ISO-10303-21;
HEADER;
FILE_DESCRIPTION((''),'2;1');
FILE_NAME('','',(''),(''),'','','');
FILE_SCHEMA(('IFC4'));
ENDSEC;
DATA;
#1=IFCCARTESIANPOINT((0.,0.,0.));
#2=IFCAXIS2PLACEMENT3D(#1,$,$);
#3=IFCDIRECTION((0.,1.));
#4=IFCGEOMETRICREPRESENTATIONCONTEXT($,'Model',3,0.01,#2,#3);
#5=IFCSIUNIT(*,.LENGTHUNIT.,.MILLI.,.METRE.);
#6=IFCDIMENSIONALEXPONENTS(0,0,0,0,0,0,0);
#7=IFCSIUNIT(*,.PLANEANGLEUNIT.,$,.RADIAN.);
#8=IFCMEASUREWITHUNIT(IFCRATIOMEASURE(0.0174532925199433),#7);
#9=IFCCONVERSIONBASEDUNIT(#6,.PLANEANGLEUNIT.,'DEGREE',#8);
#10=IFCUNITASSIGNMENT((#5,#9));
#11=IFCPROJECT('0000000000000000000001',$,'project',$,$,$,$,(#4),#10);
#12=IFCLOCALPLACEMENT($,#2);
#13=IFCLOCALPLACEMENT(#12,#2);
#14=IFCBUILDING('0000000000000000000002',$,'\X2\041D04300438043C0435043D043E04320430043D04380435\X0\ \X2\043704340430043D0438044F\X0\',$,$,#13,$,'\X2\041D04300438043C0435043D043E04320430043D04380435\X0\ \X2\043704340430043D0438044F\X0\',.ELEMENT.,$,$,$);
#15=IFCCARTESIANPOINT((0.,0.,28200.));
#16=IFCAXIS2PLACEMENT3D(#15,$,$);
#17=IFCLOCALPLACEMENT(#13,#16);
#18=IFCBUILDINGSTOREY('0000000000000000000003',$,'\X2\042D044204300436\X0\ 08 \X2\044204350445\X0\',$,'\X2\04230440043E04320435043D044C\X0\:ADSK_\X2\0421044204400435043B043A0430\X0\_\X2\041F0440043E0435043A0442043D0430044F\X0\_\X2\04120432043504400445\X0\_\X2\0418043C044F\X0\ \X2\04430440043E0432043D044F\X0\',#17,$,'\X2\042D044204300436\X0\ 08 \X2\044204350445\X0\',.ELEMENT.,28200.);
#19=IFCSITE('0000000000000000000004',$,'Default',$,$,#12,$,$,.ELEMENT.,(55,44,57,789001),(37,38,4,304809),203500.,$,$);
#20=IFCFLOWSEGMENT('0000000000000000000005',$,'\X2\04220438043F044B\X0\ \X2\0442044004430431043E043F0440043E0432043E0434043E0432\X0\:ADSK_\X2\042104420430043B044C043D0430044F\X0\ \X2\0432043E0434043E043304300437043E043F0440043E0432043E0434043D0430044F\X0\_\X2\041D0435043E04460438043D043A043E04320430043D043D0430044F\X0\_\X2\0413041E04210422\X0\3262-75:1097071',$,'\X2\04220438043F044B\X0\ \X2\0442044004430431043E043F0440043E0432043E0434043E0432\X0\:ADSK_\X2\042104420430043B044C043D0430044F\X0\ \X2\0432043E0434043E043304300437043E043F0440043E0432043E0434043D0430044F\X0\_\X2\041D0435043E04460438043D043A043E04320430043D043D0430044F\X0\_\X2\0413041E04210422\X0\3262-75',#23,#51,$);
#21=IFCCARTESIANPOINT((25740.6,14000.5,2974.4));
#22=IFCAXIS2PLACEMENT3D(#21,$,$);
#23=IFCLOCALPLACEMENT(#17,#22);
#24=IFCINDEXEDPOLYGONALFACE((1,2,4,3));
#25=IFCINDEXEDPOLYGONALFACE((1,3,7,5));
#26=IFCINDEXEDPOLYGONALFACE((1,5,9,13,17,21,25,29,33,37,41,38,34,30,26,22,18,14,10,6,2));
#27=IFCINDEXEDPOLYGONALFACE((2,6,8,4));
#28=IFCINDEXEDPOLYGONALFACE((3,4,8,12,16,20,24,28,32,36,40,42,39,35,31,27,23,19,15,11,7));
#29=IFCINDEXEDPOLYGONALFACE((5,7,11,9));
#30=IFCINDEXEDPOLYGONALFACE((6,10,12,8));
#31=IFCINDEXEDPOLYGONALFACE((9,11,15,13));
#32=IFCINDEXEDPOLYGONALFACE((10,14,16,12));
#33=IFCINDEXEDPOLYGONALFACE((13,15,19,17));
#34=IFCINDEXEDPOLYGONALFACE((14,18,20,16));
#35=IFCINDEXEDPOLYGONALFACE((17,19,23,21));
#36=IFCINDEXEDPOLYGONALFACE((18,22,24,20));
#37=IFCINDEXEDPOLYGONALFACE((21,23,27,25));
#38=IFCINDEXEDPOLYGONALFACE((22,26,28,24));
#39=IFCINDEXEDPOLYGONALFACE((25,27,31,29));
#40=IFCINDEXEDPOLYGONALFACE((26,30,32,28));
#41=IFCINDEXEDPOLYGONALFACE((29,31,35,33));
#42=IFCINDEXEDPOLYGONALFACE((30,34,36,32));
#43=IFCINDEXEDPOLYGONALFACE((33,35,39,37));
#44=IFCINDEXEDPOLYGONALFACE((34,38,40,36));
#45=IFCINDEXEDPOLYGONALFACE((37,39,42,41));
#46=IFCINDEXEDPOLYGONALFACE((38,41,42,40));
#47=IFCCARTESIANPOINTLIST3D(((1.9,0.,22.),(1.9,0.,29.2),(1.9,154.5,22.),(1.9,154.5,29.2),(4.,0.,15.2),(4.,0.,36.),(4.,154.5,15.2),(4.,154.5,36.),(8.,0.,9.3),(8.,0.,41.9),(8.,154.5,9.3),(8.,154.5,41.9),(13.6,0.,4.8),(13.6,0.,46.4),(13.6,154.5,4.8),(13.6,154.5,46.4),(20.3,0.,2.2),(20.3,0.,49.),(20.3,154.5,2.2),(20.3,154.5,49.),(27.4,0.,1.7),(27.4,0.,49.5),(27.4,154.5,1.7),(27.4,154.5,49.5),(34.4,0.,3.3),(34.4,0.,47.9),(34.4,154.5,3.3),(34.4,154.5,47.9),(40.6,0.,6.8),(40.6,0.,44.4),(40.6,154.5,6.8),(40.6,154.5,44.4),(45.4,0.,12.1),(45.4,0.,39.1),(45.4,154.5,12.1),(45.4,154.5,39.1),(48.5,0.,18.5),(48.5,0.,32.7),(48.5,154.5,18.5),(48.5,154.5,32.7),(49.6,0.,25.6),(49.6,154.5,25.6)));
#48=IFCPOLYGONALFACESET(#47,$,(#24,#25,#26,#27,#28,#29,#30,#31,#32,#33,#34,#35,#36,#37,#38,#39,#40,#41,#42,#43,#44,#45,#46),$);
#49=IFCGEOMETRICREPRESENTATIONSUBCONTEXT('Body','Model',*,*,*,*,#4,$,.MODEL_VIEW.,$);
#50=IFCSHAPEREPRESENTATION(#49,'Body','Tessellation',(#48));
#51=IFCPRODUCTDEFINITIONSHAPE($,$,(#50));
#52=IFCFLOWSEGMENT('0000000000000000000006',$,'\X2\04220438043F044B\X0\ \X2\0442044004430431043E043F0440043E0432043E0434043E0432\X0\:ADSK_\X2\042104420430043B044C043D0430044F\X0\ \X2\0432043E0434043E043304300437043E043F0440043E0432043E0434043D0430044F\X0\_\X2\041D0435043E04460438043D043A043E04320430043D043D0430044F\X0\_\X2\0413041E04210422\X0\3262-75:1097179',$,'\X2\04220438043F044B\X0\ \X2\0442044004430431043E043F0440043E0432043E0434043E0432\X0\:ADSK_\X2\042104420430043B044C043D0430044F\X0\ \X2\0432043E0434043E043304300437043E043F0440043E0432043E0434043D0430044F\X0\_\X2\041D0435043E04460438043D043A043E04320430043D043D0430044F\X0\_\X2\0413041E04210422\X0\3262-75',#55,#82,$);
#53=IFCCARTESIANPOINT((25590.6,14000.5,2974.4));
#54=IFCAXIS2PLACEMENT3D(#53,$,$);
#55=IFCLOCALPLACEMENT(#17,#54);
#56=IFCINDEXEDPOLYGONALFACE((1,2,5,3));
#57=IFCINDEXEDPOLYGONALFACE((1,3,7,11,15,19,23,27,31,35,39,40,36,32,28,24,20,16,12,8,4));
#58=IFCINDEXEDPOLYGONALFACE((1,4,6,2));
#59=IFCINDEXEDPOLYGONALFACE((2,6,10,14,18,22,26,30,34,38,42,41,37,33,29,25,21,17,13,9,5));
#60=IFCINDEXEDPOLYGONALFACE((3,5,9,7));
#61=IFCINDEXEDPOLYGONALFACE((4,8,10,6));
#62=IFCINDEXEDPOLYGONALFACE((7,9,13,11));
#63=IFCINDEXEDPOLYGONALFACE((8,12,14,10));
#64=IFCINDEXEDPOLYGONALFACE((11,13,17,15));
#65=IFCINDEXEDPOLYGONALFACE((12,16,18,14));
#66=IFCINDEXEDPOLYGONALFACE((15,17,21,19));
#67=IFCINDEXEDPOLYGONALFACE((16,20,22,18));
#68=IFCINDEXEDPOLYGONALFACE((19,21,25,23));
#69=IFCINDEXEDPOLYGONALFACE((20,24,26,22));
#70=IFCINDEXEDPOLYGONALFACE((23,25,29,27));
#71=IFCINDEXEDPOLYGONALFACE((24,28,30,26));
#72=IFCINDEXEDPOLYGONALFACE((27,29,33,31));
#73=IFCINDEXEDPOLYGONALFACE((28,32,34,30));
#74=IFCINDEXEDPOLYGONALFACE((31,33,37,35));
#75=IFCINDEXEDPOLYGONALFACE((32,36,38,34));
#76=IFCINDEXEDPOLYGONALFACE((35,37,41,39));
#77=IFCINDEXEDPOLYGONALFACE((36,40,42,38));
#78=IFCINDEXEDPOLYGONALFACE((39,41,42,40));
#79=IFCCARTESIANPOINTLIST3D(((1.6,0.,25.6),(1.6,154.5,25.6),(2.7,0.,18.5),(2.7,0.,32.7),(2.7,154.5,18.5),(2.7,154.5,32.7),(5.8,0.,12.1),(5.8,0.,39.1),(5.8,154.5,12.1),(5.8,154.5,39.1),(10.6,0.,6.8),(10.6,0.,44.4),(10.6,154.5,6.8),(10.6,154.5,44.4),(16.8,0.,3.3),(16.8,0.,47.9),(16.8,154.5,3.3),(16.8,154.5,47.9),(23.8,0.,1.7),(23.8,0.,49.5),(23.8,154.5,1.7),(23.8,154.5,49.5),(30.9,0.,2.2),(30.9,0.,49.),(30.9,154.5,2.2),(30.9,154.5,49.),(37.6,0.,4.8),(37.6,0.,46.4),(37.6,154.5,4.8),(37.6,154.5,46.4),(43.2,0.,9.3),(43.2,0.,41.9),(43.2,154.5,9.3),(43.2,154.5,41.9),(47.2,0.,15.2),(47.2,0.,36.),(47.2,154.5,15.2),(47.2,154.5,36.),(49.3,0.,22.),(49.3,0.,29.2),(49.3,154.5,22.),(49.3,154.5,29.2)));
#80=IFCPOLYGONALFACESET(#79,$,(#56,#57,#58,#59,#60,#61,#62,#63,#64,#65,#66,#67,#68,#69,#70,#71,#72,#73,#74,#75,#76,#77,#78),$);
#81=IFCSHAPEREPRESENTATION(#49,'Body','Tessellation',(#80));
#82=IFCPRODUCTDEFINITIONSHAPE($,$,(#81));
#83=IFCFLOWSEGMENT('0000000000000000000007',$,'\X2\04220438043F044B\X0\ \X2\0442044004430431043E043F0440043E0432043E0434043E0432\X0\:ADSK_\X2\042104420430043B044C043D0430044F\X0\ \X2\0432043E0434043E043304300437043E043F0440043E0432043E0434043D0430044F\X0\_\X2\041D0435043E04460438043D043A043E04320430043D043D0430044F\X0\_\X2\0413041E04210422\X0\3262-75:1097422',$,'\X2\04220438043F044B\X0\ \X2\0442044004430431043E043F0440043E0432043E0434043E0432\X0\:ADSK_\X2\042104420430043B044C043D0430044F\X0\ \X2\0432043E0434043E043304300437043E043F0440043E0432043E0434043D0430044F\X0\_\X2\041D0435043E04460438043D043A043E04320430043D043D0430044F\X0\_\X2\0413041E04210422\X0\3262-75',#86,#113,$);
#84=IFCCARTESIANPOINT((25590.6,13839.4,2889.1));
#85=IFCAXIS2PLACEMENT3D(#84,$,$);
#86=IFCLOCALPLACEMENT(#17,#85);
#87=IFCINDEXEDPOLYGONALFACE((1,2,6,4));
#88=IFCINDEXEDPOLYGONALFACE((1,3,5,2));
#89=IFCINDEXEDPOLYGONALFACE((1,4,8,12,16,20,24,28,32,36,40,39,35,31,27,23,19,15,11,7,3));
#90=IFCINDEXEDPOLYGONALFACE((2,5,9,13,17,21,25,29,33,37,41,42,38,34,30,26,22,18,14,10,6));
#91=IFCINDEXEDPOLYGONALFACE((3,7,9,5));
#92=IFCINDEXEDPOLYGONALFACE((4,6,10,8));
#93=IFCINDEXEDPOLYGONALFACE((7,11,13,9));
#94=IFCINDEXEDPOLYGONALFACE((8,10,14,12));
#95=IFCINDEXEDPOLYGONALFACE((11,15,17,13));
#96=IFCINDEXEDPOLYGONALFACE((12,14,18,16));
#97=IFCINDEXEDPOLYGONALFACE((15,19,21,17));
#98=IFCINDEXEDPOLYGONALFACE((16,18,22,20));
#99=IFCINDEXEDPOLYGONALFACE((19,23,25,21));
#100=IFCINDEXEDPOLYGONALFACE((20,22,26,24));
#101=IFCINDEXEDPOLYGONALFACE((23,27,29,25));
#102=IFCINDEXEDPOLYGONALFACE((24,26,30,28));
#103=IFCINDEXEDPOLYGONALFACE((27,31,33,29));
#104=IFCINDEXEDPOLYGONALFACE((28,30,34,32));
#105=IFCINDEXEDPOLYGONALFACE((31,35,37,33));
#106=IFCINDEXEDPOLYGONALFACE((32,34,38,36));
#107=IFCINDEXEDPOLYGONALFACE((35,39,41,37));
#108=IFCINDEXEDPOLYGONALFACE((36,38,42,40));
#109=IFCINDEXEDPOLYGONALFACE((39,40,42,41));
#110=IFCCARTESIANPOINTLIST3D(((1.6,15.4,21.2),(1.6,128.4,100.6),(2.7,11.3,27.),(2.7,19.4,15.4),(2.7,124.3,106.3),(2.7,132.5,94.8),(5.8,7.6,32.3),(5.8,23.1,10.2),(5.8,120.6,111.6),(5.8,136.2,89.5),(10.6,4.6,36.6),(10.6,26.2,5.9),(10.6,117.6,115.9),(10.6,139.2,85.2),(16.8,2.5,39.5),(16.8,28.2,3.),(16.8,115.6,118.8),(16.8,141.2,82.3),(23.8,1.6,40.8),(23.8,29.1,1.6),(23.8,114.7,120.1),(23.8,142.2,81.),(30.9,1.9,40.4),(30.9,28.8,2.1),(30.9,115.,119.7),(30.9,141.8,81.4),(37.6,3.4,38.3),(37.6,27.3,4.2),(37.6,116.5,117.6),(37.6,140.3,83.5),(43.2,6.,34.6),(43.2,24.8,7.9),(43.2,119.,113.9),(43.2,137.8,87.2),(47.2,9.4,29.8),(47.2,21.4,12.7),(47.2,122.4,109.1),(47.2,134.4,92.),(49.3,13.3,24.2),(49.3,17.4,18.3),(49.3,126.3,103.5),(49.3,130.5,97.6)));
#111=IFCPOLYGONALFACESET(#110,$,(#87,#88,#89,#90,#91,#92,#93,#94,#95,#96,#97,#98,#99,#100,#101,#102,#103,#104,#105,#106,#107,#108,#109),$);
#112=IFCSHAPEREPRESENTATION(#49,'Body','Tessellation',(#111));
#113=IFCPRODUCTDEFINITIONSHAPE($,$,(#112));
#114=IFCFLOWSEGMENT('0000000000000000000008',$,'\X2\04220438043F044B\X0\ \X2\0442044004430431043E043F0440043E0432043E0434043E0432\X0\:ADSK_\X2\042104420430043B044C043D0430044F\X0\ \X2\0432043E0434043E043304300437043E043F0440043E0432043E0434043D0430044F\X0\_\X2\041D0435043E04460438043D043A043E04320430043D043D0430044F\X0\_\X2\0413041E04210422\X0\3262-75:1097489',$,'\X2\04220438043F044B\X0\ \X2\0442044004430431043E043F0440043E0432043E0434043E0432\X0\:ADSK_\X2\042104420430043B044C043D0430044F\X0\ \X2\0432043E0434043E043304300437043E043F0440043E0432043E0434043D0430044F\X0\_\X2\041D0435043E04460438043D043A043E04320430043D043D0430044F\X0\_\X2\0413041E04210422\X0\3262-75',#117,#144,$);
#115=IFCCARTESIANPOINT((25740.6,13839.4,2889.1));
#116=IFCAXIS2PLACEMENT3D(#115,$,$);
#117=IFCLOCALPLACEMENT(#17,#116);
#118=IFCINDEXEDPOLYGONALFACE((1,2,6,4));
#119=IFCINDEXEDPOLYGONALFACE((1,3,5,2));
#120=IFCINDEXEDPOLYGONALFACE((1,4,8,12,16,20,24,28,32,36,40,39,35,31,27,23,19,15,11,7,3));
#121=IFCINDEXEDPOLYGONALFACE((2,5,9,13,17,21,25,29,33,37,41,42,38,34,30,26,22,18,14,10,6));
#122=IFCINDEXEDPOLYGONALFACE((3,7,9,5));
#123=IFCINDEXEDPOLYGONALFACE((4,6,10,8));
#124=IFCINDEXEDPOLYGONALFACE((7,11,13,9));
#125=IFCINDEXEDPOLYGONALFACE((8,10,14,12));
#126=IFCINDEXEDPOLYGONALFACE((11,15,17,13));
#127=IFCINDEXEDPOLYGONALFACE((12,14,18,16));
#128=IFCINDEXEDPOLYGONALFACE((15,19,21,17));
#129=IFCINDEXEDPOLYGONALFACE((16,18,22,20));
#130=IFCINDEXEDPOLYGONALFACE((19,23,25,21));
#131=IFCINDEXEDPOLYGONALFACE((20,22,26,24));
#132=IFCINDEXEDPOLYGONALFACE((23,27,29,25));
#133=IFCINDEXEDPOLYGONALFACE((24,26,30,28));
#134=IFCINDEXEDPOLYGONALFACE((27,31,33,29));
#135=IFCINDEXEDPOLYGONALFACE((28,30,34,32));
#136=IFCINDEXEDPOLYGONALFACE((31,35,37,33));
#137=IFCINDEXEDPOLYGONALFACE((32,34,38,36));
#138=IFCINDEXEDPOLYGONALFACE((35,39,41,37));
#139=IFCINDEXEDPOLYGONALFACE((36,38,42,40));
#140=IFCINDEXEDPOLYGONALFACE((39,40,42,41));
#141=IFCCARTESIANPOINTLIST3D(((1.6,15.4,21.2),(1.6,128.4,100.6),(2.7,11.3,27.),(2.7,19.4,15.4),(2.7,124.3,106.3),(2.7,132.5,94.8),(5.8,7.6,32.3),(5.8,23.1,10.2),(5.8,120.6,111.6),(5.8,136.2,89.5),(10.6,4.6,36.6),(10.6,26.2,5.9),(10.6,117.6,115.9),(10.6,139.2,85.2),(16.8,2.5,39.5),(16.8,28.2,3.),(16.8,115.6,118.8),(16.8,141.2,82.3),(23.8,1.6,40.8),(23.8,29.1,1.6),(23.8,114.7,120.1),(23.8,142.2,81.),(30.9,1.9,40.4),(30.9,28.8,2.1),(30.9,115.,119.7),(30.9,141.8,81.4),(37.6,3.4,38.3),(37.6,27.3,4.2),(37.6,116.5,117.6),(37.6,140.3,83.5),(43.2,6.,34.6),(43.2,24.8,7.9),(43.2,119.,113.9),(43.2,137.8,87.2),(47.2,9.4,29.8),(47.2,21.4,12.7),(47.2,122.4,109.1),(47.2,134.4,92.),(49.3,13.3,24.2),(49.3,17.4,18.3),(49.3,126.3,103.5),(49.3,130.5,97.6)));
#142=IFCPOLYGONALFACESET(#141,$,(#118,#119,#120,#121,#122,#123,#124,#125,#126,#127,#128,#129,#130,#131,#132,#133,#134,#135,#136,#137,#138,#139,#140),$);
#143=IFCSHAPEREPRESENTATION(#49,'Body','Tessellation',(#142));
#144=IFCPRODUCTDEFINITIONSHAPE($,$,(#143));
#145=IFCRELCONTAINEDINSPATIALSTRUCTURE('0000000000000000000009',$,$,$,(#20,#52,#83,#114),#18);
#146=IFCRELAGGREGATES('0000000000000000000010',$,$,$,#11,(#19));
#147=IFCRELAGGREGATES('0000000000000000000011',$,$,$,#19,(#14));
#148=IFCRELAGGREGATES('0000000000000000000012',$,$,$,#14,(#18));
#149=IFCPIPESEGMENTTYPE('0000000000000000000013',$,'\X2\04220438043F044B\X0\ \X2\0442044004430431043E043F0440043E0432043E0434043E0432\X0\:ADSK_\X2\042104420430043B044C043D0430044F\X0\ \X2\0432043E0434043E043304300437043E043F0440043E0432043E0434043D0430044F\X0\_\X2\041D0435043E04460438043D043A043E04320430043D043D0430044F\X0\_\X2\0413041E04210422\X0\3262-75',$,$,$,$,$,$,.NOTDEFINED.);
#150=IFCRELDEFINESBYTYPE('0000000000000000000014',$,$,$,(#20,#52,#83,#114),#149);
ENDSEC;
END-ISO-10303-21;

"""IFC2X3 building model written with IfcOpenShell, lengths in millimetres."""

from ifc_helpers import new_model, entity, si_unit, converted_unit, direction, frame, origin, origin_2d_with_axis, place, context, subcontext, project, spatial, circle, extrude, type_object, element, save


model = new_model("IFC2X3")

# Units and contexts
model_context = context("Model", 3, precision=0.01, world=origin(), true_north=direction((0.0, 1.0)))
body_context = subcontext(model_context, "Body", "Model", "MODEL_VIEW")
ifc_project = project(units=[si_unit("LENGTHUNIT", "METRE", prefix="MILLI"), converted_unit("PLANEANGLEUNIT", "DEGREE", entity("IfcRatioMeasure", 0.0174532925199433), si_unit("PLANEANGLEUNIT", "RADIAN"), dimensions=[0, 0, 0, 0, 0, 0, 0])], contexts=[model_context])

# Site, building, storey
site_placement = place(None, origin())
site = spatial("IfcSite", under=ifc_project, at=site_placement, Name="Default", CompositionType="ELEMENT", RefLatitude=(55, 44, 57, 789001), RefLongitude=(37, 38, 4, 304809), RefElevation=203500.0)
building_placement = place(site_placement, origin())
building = spatial("IfcBuilding", under=site, at=building_placement, Name="Наименование здания", LongName="Наименование здания", CompositionType="ELEMENT")
storey_placement = place(building_placement, frame((0.0, 0.0, 28200.0)))
storey = spatial("IfcBuildingStorey", under=building, at=storey_placement, Name="Этаж 08 тех", ObjectType="Уровень:ADSK_Стрелка_Проектная_Вверх_Имя уровня", LongName="Этаж 08 тех", CompositionType="ELEMENT", Elevation=28200.0)

# Flow segments
pipe_segment_type_1 = type_object("IfcPipeSegmentType", Name="Типы трубопроводов:ADSK_Стальная водогазопроводная_Неоцинкованная_ГОСТ3262-75", PredefinedType="NOTDEFINED")
flow_segment_1_placement = place(storey_placement, frame((25740.6, 14000.5, 2974.4)))
element("IfcFlowSegment", 1, at=flow_segment_1_placement, inside=storey, type_object=pipe_segment_type_1, Name="Типы трубопроводов:ADSK_Стальная водогазопроводная_Неоцинкованная_ГОСТ3262-75:1097071", ObjectType="Типы трубопроводов:ADSK_Стальная водогазопроводная_Неоцинкованная_ГОСТ3262-75", context=body_context, shape_type="SweptSolid", body=[
    extrude(circle(Radius=24.0, at=origin_2d_with_axis()), frame((25.6, 0.0, 25.6), z_axis=(0.0, 1.0, 0.0), x_axis=(1.0, 0.0, 0.0)), (0.0, 0.0, 1.0), 154.5),
])
flow_segment_2_placement = place(storey_placement, frame((25590.6, 14000.5, 2974.4)))
element("IfcFlowSegment", 2, at=flow_segment_2_placement, inside=storey, type_object=pipe_segment_type_1, Name="Типы трубопроводов:ADSK_Стальная водогазопроводная_Неоцинкованная_ГОСТ3262-75:1097179", ObjectType="Типы трубопроводов:ADSK_Стальная водогазопроводная_Неоцинкованная_ГОСТ3262-75", context=body_context, shape_type="SweptSolid", body=[
    extrude(circle(Radius=24.0, at=origin_2d_with_axis()), frame((25.6, 0.0, 25.6), z_axis=(0.0, 1.0, 0.0), x_axis=(-1.0, 0.0, 0.0)), (0.0, 0.0, 1.0), 154.5),
])
flow_segment_3_placement = place(storey_placement, frame((25590.6, 13839.4, 2889.1)))
element("IfcFlowSegment", 3, at=flow_segment_3_placement, inside=storey, type_object=pipe_segment_type_1, Name="Типы трубопроводов:ADSK_Стальная водогазопроводная_Неоцинкованная_ГОСТ3262-75:1097422", ObjectType="Типы трубопроводов:ADSK_Стальная водогазопроводная_Неоцинкованная_ГОСТ3262-75", context=body_context, shape_type="SweptSolid", body=[
    extrude(circle(Radius=24.0, at=origin_2d_with_axis()), frame((25.6, 15.4, 21.2), z_axis=(0.0, 0.818557, 0.574426), x_axis=(-1.0, 0.0, 0.0)), (0.0, 0.0, 1.0), 138.1),
])
flow_segment_4_placement = place(storey_placement, frame((25740.6, 13839.4, 2889.1)))
element("IfcFlowSegment", 4, at=flow_segment_4_placement, inside=storey, type_object=pipe_segment_type_1, Name="Типы трубопроводов:ADSK_Стальная водогазопроводная_Неоцинкованная_ГОСТ3262-75:1097489", ObjectType="Типы трубопроводов:ADSK_Стальная водогазопроводная_Неоцинкованная_ГОСТ3262-75", context=body_context, shape_type="SweptSolid", body=[
    extrude(circle(Radius=24.0, at=origin_2d_with_axis()), frame((25.6, 15.4, 21.2), z_axis=(0.0, 0.818557, 0.574426), x_axis=(-1.0, 0.0, 0.0)), (0.0, 0.0, 1.0), 138.1),
])

save(model, "model.ifc")
